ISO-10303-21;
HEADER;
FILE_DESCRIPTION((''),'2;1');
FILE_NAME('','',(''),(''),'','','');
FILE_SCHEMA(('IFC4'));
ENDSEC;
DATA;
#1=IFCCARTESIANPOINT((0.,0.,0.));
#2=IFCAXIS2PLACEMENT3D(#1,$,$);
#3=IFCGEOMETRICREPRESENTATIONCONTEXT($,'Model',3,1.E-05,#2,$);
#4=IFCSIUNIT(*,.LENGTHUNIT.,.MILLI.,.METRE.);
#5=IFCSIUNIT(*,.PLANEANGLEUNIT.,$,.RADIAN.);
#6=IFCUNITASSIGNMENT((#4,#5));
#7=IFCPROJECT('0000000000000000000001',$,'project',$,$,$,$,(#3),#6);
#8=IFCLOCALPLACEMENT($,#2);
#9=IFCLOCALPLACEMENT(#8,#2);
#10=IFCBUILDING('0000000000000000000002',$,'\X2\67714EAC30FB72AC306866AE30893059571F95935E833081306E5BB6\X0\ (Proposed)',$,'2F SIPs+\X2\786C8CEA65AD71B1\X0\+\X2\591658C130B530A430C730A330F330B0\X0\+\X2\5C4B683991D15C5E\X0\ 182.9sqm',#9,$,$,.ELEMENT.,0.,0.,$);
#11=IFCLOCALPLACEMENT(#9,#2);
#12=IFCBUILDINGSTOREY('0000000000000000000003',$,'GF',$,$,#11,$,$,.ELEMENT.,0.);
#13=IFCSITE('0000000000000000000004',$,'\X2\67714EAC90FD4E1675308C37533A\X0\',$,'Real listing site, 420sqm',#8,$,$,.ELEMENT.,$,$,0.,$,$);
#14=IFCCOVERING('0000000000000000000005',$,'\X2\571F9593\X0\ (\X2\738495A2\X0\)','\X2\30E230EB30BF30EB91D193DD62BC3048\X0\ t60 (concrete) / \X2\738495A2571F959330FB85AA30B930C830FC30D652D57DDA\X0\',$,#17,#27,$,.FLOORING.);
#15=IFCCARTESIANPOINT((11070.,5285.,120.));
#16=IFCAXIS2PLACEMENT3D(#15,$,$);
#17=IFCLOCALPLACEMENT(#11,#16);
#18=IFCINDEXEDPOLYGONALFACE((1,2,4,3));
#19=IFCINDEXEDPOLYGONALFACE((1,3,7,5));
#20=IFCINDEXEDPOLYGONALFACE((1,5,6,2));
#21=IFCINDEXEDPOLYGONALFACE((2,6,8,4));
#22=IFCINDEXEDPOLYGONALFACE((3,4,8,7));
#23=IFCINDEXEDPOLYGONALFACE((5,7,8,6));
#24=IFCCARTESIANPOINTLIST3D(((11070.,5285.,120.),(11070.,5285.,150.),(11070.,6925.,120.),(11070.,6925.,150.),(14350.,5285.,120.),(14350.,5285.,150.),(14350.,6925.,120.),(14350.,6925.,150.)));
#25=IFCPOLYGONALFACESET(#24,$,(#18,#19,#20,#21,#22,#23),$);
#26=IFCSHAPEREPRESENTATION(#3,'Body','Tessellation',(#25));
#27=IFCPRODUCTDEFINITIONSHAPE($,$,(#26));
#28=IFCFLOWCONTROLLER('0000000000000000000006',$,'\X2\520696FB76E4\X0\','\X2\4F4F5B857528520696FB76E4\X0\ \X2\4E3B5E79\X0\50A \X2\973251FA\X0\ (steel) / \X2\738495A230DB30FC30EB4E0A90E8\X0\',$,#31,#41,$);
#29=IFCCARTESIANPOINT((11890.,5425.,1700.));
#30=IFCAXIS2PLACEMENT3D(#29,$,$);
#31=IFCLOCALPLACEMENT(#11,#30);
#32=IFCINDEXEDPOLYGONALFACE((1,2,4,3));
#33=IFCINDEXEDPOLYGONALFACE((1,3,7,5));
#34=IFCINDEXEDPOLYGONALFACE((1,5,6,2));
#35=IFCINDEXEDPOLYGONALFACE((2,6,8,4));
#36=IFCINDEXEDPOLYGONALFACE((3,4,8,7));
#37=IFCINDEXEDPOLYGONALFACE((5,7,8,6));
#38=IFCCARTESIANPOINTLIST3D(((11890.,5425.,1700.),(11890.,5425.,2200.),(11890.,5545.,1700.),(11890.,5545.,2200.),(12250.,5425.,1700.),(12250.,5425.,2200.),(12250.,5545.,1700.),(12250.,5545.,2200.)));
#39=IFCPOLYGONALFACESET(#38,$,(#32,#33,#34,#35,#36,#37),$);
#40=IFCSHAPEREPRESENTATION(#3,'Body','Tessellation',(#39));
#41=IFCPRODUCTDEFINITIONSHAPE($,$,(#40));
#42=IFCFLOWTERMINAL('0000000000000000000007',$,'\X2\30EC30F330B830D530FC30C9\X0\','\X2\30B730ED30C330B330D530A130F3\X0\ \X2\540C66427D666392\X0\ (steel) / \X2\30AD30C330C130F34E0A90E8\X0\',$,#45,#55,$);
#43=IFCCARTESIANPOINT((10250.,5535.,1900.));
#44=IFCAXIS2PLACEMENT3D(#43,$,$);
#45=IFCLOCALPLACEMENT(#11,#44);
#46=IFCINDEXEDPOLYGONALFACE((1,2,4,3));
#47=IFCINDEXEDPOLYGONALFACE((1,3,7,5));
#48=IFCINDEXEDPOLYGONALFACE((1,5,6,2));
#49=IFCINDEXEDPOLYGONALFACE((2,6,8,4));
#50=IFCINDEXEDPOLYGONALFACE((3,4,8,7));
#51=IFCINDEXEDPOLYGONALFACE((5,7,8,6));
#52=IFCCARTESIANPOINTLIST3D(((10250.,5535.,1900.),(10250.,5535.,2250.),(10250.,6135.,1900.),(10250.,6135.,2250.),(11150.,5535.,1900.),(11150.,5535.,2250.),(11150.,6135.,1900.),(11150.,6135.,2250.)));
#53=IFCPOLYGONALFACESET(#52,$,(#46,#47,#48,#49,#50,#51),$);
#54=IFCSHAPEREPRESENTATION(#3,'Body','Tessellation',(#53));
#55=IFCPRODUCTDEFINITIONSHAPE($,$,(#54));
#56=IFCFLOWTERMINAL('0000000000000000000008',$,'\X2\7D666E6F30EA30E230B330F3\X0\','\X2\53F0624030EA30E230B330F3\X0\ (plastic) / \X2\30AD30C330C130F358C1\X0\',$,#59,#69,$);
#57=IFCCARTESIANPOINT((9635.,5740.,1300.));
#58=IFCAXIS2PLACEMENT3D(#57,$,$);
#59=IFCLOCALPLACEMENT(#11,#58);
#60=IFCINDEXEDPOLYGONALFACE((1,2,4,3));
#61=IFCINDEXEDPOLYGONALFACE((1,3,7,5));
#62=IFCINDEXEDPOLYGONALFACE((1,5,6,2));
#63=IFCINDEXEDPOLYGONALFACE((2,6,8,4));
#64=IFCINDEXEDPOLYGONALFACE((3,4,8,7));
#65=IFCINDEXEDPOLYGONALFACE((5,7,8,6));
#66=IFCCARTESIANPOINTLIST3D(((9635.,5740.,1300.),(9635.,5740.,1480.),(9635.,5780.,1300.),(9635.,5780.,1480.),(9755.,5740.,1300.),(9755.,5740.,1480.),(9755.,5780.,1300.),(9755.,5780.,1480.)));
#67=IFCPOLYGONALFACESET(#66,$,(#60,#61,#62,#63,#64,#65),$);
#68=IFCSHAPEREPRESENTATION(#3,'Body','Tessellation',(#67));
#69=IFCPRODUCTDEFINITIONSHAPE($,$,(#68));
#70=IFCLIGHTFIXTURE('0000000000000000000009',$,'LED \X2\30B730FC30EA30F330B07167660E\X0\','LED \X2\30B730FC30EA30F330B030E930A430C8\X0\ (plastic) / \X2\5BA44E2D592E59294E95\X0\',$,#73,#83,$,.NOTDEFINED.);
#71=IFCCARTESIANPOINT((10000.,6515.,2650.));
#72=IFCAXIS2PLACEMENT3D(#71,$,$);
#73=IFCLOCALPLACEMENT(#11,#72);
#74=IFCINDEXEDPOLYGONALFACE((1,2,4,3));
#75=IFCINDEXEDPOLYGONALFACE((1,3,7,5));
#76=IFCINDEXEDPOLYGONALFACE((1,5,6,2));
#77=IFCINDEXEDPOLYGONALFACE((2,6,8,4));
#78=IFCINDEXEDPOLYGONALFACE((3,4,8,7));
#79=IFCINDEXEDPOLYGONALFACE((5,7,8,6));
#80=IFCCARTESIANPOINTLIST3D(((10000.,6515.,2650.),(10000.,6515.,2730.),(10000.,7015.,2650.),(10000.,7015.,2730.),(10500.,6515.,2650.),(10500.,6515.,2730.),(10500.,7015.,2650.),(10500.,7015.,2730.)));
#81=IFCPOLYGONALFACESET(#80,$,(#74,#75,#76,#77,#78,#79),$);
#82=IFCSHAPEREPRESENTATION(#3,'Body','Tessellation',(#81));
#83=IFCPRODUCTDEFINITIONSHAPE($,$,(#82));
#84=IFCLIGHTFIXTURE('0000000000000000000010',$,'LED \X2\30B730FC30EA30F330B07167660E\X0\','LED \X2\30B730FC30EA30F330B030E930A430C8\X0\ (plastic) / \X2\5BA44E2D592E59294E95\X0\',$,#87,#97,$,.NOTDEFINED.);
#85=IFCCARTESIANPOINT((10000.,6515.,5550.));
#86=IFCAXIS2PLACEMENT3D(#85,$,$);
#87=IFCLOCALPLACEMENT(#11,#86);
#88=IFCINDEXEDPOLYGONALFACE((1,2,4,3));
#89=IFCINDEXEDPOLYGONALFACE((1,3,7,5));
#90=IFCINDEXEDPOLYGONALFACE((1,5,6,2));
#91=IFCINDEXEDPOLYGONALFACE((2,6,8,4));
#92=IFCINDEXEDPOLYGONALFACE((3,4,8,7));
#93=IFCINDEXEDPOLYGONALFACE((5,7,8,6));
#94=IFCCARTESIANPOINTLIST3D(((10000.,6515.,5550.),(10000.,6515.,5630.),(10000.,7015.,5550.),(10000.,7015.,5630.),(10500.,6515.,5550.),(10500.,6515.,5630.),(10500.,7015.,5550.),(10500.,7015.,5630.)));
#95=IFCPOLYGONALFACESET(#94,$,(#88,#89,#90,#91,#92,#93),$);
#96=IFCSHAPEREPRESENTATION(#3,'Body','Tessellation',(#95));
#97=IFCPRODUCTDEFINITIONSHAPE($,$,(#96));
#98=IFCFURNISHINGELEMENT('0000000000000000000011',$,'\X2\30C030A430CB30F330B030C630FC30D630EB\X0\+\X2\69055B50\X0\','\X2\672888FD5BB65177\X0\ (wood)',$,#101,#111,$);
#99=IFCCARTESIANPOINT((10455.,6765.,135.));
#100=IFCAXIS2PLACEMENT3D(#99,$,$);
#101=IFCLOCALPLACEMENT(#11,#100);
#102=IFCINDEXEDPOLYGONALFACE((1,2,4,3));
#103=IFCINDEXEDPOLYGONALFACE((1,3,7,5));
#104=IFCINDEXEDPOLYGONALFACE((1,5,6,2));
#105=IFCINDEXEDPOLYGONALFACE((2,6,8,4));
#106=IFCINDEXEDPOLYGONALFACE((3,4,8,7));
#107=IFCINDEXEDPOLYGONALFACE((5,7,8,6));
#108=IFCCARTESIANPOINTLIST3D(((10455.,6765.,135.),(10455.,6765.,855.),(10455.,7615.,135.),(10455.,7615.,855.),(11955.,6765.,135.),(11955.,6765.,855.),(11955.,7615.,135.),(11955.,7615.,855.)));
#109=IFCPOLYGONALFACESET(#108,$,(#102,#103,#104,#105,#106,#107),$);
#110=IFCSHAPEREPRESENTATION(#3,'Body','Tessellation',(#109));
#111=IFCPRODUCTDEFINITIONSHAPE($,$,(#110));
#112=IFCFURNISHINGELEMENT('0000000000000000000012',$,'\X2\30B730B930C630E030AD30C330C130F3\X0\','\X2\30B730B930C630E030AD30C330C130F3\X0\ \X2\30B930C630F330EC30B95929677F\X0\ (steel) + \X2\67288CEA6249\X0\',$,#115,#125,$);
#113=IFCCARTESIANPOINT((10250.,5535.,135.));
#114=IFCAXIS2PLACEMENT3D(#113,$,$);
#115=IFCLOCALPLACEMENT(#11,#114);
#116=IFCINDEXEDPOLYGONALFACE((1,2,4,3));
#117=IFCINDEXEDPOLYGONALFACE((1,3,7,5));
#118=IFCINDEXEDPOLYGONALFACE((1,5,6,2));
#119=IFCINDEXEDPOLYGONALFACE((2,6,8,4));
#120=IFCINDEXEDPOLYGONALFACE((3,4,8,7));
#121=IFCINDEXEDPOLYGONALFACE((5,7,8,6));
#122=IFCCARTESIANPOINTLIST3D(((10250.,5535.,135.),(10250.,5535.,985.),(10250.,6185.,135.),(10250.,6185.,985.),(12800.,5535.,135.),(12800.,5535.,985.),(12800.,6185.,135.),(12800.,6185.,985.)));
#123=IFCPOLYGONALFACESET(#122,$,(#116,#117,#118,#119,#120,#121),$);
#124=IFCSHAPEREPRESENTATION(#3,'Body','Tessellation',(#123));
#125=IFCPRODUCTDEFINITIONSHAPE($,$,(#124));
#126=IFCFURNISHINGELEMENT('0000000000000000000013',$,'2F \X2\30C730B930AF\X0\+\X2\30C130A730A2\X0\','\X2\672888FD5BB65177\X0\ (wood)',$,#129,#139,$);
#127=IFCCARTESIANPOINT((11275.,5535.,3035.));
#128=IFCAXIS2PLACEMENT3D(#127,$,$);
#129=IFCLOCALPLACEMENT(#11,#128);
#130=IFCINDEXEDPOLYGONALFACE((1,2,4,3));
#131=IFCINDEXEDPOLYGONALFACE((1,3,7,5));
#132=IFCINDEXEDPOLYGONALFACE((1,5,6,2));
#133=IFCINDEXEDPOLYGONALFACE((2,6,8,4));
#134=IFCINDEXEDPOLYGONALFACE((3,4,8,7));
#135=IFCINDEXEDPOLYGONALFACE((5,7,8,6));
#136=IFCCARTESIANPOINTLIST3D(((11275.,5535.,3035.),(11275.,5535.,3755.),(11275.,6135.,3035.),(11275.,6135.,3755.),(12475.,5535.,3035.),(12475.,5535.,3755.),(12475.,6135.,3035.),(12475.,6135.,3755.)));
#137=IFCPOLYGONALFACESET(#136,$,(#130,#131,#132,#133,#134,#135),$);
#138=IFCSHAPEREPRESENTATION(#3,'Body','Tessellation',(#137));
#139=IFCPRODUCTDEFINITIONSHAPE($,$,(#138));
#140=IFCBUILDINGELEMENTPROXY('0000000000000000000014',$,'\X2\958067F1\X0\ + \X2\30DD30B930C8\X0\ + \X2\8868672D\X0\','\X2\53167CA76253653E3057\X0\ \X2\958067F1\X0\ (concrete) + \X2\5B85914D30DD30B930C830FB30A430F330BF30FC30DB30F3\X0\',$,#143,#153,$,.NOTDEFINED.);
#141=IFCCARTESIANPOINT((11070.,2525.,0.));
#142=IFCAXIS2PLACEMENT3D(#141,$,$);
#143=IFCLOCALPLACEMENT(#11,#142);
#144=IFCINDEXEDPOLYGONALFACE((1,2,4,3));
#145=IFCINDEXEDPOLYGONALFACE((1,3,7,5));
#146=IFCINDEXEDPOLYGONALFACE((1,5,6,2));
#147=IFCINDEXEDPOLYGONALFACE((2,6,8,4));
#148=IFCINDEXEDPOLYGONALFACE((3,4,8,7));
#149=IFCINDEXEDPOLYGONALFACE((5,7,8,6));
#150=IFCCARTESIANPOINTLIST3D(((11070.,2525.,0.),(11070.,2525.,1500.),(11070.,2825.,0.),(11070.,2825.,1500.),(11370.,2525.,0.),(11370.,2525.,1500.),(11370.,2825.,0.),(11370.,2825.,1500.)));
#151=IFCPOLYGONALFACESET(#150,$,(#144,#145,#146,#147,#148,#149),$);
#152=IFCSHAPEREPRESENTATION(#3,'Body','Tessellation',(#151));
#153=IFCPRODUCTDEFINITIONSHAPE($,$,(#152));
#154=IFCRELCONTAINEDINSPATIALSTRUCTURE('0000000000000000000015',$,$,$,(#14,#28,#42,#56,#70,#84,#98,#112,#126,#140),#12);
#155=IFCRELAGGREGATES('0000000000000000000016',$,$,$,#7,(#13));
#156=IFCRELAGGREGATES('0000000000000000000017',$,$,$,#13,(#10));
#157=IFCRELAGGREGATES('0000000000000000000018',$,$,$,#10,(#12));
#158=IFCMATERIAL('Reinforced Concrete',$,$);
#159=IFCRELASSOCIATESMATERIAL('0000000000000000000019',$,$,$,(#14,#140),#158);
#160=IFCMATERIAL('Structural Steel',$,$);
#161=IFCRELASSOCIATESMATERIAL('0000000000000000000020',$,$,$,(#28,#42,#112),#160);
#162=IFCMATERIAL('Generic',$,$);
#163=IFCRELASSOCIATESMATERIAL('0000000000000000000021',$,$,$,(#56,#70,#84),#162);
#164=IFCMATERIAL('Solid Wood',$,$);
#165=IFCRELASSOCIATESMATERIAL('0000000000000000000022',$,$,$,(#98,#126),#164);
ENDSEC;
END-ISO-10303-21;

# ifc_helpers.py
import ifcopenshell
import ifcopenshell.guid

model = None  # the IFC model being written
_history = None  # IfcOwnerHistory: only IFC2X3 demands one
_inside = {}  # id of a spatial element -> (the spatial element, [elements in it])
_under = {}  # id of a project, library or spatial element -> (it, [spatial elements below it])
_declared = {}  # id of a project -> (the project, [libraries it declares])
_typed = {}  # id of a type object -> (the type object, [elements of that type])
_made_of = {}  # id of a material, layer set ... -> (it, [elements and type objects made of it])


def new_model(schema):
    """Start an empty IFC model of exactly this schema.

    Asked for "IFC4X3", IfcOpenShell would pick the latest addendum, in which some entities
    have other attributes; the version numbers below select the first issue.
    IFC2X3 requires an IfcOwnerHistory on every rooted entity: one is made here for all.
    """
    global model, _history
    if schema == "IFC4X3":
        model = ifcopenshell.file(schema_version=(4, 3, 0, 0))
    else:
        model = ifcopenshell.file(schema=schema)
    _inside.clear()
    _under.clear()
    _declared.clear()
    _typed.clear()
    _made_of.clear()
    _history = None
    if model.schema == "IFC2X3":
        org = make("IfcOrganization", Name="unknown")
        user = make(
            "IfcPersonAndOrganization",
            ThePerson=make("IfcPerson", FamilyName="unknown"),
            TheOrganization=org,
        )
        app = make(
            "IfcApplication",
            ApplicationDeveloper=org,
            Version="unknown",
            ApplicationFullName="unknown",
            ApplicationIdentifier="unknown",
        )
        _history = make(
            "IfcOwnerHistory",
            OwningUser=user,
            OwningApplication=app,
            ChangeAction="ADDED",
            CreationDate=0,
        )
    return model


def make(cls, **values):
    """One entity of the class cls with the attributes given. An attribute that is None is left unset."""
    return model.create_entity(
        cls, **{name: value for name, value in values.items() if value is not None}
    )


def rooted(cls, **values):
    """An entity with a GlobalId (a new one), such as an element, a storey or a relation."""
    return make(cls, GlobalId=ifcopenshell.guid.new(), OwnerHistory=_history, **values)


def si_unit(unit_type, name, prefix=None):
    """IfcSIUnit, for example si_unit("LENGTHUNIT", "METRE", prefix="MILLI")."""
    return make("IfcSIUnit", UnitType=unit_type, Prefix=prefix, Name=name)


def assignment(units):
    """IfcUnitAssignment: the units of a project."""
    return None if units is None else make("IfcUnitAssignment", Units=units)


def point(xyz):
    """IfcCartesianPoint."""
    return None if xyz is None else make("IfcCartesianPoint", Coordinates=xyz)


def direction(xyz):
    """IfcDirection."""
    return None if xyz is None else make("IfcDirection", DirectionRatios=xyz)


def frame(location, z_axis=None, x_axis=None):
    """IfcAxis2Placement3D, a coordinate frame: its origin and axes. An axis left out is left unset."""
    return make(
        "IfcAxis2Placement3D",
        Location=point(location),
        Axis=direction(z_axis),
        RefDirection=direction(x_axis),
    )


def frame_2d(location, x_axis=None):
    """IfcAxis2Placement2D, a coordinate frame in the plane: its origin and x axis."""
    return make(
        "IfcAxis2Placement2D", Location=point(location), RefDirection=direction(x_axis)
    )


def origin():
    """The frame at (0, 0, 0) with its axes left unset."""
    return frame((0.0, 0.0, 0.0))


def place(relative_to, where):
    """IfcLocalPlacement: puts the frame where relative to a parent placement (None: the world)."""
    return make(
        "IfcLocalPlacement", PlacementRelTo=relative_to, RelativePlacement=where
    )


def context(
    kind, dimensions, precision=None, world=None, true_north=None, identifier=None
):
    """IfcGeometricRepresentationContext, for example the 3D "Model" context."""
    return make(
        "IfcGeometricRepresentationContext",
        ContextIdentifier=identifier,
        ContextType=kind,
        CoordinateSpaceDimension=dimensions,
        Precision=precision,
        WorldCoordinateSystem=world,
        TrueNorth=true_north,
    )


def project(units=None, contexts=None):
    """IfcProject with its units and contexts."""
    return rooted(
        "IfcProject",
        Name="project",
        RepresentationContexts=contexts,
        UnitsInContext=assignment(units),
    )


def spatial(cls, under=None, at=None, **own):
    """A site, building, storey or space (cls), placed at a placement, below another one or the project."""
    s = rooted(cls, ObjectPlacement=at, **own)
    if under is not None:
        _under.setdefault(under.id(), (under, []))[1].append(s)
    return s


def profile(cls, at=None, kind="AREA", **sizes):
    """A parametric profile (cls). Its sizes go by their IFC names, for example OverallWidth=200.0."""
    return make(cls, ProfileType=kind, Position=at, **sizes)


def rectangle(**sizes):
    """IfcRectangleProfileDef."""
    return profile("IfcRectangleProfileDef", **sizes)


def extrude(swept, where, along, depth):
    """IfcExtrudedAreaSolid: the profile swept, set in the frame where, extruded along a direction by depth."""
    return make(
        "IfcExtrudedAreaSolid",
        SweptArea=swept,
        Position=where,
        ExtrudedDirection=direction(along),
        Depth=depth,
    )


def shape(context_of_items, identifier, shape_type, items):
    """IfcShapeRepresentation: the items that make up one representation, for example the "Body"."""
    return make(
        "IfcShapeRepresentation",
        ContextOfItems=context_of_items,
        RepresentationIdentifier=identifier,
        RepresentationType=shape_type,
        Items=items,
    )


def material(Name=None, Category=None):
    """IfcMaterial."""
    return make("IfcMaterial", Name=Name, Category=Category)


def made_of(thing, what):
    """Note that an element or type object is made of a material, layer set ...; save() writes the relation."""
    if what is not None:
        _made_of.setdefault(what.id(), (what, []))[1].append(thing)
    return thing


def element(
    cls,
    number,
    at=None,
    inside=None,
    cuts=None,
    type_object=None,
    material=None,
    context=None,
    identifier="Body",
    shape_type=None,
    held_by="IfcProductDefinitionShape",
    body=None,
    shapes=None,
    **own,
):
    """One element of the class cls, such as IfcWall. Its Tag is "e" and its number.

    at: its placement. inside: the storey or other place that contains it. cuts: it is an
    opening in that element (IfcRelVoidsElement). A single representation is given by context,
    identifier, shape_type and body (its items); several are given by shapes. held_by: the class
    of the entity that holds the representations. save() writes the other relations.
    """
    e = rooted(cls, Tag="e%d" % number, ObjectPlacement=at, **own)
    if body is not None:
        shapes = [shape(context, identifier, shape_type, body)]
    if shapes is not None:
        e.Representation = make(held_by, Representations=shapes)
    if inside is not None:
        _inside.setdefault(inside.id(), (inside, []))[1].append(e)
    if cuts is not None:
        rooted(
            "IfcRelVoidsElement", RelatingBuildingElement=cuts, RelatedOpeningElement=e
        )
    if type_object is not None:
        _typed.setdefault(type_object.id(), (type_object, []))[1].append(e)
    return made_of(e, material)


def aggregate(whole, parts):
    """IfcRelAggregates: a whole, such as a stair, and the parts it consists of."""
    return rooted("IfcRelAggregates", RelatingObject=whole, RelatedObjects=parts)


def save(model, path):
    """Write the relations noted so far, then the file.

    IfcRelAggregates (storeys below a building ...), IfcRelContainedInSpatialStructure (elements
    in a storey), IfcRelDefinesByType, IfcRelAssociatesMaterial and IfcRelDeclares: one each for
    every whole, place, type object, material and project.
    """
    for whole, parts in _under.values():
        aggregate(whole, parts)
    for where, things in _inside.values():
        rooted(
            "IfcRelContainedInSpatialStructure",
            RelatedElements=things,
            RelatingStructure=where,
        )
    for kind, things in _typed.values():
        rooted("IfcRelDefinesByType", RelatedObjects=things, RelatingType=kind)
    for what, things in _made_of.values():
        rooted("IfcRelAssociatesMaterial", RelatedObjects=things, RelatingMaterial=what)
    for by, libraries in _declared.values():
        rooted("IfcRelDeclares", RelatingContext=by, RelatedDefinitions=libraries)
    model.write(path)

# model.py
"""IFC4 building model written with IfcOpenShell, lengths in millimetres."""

from ifc_helpers import new_model, si_unit, frame, frame_2d, origin, place, context, project, spatial, rectangle, extrude, material, element, save


model = new_model("IFC4")

# Units and contexts
model_context = context("Model", 3, precision=1e-05, world=origin())
ifc_project = project(units=[si_unit("LENGTHUNIT", "METRE", prefix="MILLI"), si_unit("PLANEANGLEUNIT", "RADIAN")], contexts=[model_context])

# Site, building, storey
site_placement = place(None, origin())
site = spatial("IfcSite", under=ifc_project, at=site_placement, Name="東京都世田谷区", ObjectType="Real listing site, 420sqm", CompositionType="ELEMENT", RefElevation=0.0)
building_placement = place(site_placement, origin())
building = spatial("IfcBuilding", under=site, at=building_placement, Name="東京・犬と暮らす土間広めの家 (Proposed)", ObjectType="2F SIPs+硬質断熱+外壁サイディング+屋根金属 182.9sqm", CompositionType="ELEMENT", ElevationOfRefHeight=0.0, ElevationOfTerrain=0.0)
storey_placement = place(building_placement, origin())
storey = spatial("IfcBuildingStorey", under=building, at=storey_placement, Name="GF", CompositionType="ELEMENT", Elevation=0.0)

# Shared definitions
ifc_material_1 = material(Name="Solid Wood")

# Shared definitions
ifc_material_2 = material(Name="Structural Steel")

# Covering
ifc_material_3 = material(Name="Reinforced Concrete")
covering_1_placement = place(storey_placement, frame((11070.0, 5285.0, 120.0)))
element("IfcCovering", 1, at=covering_1_placement, inside=storey, material=ifc_material_3, Name="土間 (玄関)", Description="モルタル金鏝押え t60 (concrete) / 玄関土間・薪ストーブ動線", PredefinedType="FLOORING", context=model_context, shape_type="SweptSolid", body=[
    extrude(rectangle(XDim=3280.0, YDim=1640.0, at=frame_2d((1640.0, 820.0))), frame((11070.0, 5285.0, 120.0)), (0.0, 0.0, 1.0), 30.0),
])

# Flow controller
flow_controller_placement = place(storey_placement, frame((11890.0, 5425.0, 1700.0)))
element("IfcFlowController", 2, at=flow_controller_placement, inside=storey, material=ifc_material_2, Name="分電盤", Description="住宅用分電盤 主幹50A 露出 (steel) / 玄関ホール上部", context=model_context, shape_type="SweptSolid", body=[
    extrude(rectangle(XDim=360.0, YDim=120.0, at=frame_2d((180.0, 60.0))), frame((11890.0, 5425.0, 1700.0)), (0.0, 0.0, 1.0), 500.0),
])

# Flow terminals
flow_terminal_1_placement = place(storey_placement, frame((10250.0, 5535.0, 1900.0)))
element("IfcFlowTerminal", 3, at=flow_terminal_1_placement, inside=storey, material=ifc_material_2, Name="レンジフード", Description="シロッコファン 同時給排 (steel) / キッチン上部", context=model_context, shape_type="SweptSolid", body=[
    extrude(rectangle(XDim=900.0, YDim=600.0, at=frame_2d((450.0, 300.0))), frame((10250.0, 5535.0, 1900.0)), (0.0, 0.0, 1.0), 350.0),
])
ifc_material_4 = material(Name="Generic")
flow_terminal_2_placement = place(storey_placement, frame((9635.0, 5740.0, 1300.0)))
element("IfcFlowTerminal", 4, at=flow_terminal_2_placement, inside=storey, material=ifc_material_4, Name="給湯リモコン", Description="台所リモコン (plastic) / キッチン壁", context=model_context, shape_type="SweptSolid", body=[
    extrude(rectangle(XDim=120.0, YDim=40.0, at=frame_2d((60.0, 20.0))), frame((9635.0, 5740.0, 1300.0)), (0.0, 0.0, 1.0), 180.0),
])

# Light fixtures
light_fixture_1_placement = place(storey_placement, frame((10000.0, 6515.0, 2650.0)))
element("IfcLightFixture", 5, at=light_fixture_1_placement, inside=storey, material=ifc_material_4, Name="LED シーリング照明", Description="LED シーリングライト (plastic) / 室中央天井", PredefinedType="NOTDEFINED", context=model_context, shape_type="SweptSolid", body=[
    extrude(rectangle(XDim=500.0, YDim=500.0, at=frame_2d((250.0, 250.0))), frame((10000.0, 6515.0, 2650.0)), (0.0, 0.0, 1.0), 80.0),
])
light_fixture_2_placement = place(storey_placement, frame((10000.0, 6515.0, 5550.0)))
element("IfcLightFixture", 6, at=light_fixture_2_placement, inside=storey, material=ifc_material_4, Name="LED シーリング照明", Description="LED シーリングライト (plastic) / 室中央天井", PredefinedType="NOTDEFINED", context=model_context, shape_type="SweptSolid", body=[
    extrude(rectangle(XDim=500.0, YDim=500.0, at=frame_2d((250.0, 250.0))), frame((10000.0, 6515.0, 5550.0)), (0.0, 0.0, 1.0), 80.0),
])

# Furnishing elements
furnishing_1_placement = place(storey_placement, frame((10455.0, 6765.0, 135.0)))
element("IfcFurnishingElement", 7, at=furnishing_1_placement, inside=storey, material=ifc_material_1, Name="ダイニングテーブル+椅子", Description="木製家具 (wood)", context=model_context, shape_type="SweptSolid", body=[
    extrude(rectangle(XDim=1500.0, YDim=850.0, at=frame_2d((750.0, 425.0))), frame((10455.0, 6765.0, 135.0)), (0.0, 0.0, 1.0), 720.0),
])
furnishing_2_placement = place(storey_placement, frame((10250.0, 5535.0, 135.0)))
element("IfcFurnishingElement", 8, at=furnishing_2_placement, inside=storey, material=ifc_material_2, Name="システムキッチン", Description="システムキッチン ステンレス天板 (steel) + 木質扉", context=model_context, shape_type="SweptSolid", body=[
    extrude(rectangle(XDim=2550.0, YDim=650.0, at=frame_2d((1275.0, 325.0))), frame((10250.0, 5535.0, 135.0)), (0.0, 0.0, 1.0), 850.0),
])
furnishing_3_placement = place(storey_placement, frame((11275.0, 5535.0, 3035.0)))
element("IfcFurnishingElement", 9, at=furnishing_3_placement, inside=storey, material=ifc_material_1, Name="2F デスク+チェア", Description="木製家具 (wood)", context=model_context, shape_type="SweptSolid", body=[
    extrude(rectangle(XDim=1200.0, YDim=600.0, at=frame_2d((600.0, 300.0))), frame((11275.0, 5535.0, 3035.0)), (0.0, 0.0, 1.0), 720.0),
])

# Building element proxy
proxy_placement = place(storey_placement, frame((11070.0, 2525.0, 0.0)))
element("IfcBuildingElementProxy", 10, at=proxy_placement, inside=storey, material=ifc_material_3, Name="門柱 + ポスト + 表札", Description="化粧打放し 門柱 (concrete) + 宅配ポスト・インターホン", PredefinedType="NOTDEFINED", context=model_context, shape_type="SweptSolid", body=[
    extrude(rectangle(XDim=300.0, YDim=300.0, at=frame_2d((150.0, 150.0))), frame((11070.0, 2525.0, 0.0)), (0.0, 0.0, 1.0), 1500.0),
])

save(model, "model.ifc")
